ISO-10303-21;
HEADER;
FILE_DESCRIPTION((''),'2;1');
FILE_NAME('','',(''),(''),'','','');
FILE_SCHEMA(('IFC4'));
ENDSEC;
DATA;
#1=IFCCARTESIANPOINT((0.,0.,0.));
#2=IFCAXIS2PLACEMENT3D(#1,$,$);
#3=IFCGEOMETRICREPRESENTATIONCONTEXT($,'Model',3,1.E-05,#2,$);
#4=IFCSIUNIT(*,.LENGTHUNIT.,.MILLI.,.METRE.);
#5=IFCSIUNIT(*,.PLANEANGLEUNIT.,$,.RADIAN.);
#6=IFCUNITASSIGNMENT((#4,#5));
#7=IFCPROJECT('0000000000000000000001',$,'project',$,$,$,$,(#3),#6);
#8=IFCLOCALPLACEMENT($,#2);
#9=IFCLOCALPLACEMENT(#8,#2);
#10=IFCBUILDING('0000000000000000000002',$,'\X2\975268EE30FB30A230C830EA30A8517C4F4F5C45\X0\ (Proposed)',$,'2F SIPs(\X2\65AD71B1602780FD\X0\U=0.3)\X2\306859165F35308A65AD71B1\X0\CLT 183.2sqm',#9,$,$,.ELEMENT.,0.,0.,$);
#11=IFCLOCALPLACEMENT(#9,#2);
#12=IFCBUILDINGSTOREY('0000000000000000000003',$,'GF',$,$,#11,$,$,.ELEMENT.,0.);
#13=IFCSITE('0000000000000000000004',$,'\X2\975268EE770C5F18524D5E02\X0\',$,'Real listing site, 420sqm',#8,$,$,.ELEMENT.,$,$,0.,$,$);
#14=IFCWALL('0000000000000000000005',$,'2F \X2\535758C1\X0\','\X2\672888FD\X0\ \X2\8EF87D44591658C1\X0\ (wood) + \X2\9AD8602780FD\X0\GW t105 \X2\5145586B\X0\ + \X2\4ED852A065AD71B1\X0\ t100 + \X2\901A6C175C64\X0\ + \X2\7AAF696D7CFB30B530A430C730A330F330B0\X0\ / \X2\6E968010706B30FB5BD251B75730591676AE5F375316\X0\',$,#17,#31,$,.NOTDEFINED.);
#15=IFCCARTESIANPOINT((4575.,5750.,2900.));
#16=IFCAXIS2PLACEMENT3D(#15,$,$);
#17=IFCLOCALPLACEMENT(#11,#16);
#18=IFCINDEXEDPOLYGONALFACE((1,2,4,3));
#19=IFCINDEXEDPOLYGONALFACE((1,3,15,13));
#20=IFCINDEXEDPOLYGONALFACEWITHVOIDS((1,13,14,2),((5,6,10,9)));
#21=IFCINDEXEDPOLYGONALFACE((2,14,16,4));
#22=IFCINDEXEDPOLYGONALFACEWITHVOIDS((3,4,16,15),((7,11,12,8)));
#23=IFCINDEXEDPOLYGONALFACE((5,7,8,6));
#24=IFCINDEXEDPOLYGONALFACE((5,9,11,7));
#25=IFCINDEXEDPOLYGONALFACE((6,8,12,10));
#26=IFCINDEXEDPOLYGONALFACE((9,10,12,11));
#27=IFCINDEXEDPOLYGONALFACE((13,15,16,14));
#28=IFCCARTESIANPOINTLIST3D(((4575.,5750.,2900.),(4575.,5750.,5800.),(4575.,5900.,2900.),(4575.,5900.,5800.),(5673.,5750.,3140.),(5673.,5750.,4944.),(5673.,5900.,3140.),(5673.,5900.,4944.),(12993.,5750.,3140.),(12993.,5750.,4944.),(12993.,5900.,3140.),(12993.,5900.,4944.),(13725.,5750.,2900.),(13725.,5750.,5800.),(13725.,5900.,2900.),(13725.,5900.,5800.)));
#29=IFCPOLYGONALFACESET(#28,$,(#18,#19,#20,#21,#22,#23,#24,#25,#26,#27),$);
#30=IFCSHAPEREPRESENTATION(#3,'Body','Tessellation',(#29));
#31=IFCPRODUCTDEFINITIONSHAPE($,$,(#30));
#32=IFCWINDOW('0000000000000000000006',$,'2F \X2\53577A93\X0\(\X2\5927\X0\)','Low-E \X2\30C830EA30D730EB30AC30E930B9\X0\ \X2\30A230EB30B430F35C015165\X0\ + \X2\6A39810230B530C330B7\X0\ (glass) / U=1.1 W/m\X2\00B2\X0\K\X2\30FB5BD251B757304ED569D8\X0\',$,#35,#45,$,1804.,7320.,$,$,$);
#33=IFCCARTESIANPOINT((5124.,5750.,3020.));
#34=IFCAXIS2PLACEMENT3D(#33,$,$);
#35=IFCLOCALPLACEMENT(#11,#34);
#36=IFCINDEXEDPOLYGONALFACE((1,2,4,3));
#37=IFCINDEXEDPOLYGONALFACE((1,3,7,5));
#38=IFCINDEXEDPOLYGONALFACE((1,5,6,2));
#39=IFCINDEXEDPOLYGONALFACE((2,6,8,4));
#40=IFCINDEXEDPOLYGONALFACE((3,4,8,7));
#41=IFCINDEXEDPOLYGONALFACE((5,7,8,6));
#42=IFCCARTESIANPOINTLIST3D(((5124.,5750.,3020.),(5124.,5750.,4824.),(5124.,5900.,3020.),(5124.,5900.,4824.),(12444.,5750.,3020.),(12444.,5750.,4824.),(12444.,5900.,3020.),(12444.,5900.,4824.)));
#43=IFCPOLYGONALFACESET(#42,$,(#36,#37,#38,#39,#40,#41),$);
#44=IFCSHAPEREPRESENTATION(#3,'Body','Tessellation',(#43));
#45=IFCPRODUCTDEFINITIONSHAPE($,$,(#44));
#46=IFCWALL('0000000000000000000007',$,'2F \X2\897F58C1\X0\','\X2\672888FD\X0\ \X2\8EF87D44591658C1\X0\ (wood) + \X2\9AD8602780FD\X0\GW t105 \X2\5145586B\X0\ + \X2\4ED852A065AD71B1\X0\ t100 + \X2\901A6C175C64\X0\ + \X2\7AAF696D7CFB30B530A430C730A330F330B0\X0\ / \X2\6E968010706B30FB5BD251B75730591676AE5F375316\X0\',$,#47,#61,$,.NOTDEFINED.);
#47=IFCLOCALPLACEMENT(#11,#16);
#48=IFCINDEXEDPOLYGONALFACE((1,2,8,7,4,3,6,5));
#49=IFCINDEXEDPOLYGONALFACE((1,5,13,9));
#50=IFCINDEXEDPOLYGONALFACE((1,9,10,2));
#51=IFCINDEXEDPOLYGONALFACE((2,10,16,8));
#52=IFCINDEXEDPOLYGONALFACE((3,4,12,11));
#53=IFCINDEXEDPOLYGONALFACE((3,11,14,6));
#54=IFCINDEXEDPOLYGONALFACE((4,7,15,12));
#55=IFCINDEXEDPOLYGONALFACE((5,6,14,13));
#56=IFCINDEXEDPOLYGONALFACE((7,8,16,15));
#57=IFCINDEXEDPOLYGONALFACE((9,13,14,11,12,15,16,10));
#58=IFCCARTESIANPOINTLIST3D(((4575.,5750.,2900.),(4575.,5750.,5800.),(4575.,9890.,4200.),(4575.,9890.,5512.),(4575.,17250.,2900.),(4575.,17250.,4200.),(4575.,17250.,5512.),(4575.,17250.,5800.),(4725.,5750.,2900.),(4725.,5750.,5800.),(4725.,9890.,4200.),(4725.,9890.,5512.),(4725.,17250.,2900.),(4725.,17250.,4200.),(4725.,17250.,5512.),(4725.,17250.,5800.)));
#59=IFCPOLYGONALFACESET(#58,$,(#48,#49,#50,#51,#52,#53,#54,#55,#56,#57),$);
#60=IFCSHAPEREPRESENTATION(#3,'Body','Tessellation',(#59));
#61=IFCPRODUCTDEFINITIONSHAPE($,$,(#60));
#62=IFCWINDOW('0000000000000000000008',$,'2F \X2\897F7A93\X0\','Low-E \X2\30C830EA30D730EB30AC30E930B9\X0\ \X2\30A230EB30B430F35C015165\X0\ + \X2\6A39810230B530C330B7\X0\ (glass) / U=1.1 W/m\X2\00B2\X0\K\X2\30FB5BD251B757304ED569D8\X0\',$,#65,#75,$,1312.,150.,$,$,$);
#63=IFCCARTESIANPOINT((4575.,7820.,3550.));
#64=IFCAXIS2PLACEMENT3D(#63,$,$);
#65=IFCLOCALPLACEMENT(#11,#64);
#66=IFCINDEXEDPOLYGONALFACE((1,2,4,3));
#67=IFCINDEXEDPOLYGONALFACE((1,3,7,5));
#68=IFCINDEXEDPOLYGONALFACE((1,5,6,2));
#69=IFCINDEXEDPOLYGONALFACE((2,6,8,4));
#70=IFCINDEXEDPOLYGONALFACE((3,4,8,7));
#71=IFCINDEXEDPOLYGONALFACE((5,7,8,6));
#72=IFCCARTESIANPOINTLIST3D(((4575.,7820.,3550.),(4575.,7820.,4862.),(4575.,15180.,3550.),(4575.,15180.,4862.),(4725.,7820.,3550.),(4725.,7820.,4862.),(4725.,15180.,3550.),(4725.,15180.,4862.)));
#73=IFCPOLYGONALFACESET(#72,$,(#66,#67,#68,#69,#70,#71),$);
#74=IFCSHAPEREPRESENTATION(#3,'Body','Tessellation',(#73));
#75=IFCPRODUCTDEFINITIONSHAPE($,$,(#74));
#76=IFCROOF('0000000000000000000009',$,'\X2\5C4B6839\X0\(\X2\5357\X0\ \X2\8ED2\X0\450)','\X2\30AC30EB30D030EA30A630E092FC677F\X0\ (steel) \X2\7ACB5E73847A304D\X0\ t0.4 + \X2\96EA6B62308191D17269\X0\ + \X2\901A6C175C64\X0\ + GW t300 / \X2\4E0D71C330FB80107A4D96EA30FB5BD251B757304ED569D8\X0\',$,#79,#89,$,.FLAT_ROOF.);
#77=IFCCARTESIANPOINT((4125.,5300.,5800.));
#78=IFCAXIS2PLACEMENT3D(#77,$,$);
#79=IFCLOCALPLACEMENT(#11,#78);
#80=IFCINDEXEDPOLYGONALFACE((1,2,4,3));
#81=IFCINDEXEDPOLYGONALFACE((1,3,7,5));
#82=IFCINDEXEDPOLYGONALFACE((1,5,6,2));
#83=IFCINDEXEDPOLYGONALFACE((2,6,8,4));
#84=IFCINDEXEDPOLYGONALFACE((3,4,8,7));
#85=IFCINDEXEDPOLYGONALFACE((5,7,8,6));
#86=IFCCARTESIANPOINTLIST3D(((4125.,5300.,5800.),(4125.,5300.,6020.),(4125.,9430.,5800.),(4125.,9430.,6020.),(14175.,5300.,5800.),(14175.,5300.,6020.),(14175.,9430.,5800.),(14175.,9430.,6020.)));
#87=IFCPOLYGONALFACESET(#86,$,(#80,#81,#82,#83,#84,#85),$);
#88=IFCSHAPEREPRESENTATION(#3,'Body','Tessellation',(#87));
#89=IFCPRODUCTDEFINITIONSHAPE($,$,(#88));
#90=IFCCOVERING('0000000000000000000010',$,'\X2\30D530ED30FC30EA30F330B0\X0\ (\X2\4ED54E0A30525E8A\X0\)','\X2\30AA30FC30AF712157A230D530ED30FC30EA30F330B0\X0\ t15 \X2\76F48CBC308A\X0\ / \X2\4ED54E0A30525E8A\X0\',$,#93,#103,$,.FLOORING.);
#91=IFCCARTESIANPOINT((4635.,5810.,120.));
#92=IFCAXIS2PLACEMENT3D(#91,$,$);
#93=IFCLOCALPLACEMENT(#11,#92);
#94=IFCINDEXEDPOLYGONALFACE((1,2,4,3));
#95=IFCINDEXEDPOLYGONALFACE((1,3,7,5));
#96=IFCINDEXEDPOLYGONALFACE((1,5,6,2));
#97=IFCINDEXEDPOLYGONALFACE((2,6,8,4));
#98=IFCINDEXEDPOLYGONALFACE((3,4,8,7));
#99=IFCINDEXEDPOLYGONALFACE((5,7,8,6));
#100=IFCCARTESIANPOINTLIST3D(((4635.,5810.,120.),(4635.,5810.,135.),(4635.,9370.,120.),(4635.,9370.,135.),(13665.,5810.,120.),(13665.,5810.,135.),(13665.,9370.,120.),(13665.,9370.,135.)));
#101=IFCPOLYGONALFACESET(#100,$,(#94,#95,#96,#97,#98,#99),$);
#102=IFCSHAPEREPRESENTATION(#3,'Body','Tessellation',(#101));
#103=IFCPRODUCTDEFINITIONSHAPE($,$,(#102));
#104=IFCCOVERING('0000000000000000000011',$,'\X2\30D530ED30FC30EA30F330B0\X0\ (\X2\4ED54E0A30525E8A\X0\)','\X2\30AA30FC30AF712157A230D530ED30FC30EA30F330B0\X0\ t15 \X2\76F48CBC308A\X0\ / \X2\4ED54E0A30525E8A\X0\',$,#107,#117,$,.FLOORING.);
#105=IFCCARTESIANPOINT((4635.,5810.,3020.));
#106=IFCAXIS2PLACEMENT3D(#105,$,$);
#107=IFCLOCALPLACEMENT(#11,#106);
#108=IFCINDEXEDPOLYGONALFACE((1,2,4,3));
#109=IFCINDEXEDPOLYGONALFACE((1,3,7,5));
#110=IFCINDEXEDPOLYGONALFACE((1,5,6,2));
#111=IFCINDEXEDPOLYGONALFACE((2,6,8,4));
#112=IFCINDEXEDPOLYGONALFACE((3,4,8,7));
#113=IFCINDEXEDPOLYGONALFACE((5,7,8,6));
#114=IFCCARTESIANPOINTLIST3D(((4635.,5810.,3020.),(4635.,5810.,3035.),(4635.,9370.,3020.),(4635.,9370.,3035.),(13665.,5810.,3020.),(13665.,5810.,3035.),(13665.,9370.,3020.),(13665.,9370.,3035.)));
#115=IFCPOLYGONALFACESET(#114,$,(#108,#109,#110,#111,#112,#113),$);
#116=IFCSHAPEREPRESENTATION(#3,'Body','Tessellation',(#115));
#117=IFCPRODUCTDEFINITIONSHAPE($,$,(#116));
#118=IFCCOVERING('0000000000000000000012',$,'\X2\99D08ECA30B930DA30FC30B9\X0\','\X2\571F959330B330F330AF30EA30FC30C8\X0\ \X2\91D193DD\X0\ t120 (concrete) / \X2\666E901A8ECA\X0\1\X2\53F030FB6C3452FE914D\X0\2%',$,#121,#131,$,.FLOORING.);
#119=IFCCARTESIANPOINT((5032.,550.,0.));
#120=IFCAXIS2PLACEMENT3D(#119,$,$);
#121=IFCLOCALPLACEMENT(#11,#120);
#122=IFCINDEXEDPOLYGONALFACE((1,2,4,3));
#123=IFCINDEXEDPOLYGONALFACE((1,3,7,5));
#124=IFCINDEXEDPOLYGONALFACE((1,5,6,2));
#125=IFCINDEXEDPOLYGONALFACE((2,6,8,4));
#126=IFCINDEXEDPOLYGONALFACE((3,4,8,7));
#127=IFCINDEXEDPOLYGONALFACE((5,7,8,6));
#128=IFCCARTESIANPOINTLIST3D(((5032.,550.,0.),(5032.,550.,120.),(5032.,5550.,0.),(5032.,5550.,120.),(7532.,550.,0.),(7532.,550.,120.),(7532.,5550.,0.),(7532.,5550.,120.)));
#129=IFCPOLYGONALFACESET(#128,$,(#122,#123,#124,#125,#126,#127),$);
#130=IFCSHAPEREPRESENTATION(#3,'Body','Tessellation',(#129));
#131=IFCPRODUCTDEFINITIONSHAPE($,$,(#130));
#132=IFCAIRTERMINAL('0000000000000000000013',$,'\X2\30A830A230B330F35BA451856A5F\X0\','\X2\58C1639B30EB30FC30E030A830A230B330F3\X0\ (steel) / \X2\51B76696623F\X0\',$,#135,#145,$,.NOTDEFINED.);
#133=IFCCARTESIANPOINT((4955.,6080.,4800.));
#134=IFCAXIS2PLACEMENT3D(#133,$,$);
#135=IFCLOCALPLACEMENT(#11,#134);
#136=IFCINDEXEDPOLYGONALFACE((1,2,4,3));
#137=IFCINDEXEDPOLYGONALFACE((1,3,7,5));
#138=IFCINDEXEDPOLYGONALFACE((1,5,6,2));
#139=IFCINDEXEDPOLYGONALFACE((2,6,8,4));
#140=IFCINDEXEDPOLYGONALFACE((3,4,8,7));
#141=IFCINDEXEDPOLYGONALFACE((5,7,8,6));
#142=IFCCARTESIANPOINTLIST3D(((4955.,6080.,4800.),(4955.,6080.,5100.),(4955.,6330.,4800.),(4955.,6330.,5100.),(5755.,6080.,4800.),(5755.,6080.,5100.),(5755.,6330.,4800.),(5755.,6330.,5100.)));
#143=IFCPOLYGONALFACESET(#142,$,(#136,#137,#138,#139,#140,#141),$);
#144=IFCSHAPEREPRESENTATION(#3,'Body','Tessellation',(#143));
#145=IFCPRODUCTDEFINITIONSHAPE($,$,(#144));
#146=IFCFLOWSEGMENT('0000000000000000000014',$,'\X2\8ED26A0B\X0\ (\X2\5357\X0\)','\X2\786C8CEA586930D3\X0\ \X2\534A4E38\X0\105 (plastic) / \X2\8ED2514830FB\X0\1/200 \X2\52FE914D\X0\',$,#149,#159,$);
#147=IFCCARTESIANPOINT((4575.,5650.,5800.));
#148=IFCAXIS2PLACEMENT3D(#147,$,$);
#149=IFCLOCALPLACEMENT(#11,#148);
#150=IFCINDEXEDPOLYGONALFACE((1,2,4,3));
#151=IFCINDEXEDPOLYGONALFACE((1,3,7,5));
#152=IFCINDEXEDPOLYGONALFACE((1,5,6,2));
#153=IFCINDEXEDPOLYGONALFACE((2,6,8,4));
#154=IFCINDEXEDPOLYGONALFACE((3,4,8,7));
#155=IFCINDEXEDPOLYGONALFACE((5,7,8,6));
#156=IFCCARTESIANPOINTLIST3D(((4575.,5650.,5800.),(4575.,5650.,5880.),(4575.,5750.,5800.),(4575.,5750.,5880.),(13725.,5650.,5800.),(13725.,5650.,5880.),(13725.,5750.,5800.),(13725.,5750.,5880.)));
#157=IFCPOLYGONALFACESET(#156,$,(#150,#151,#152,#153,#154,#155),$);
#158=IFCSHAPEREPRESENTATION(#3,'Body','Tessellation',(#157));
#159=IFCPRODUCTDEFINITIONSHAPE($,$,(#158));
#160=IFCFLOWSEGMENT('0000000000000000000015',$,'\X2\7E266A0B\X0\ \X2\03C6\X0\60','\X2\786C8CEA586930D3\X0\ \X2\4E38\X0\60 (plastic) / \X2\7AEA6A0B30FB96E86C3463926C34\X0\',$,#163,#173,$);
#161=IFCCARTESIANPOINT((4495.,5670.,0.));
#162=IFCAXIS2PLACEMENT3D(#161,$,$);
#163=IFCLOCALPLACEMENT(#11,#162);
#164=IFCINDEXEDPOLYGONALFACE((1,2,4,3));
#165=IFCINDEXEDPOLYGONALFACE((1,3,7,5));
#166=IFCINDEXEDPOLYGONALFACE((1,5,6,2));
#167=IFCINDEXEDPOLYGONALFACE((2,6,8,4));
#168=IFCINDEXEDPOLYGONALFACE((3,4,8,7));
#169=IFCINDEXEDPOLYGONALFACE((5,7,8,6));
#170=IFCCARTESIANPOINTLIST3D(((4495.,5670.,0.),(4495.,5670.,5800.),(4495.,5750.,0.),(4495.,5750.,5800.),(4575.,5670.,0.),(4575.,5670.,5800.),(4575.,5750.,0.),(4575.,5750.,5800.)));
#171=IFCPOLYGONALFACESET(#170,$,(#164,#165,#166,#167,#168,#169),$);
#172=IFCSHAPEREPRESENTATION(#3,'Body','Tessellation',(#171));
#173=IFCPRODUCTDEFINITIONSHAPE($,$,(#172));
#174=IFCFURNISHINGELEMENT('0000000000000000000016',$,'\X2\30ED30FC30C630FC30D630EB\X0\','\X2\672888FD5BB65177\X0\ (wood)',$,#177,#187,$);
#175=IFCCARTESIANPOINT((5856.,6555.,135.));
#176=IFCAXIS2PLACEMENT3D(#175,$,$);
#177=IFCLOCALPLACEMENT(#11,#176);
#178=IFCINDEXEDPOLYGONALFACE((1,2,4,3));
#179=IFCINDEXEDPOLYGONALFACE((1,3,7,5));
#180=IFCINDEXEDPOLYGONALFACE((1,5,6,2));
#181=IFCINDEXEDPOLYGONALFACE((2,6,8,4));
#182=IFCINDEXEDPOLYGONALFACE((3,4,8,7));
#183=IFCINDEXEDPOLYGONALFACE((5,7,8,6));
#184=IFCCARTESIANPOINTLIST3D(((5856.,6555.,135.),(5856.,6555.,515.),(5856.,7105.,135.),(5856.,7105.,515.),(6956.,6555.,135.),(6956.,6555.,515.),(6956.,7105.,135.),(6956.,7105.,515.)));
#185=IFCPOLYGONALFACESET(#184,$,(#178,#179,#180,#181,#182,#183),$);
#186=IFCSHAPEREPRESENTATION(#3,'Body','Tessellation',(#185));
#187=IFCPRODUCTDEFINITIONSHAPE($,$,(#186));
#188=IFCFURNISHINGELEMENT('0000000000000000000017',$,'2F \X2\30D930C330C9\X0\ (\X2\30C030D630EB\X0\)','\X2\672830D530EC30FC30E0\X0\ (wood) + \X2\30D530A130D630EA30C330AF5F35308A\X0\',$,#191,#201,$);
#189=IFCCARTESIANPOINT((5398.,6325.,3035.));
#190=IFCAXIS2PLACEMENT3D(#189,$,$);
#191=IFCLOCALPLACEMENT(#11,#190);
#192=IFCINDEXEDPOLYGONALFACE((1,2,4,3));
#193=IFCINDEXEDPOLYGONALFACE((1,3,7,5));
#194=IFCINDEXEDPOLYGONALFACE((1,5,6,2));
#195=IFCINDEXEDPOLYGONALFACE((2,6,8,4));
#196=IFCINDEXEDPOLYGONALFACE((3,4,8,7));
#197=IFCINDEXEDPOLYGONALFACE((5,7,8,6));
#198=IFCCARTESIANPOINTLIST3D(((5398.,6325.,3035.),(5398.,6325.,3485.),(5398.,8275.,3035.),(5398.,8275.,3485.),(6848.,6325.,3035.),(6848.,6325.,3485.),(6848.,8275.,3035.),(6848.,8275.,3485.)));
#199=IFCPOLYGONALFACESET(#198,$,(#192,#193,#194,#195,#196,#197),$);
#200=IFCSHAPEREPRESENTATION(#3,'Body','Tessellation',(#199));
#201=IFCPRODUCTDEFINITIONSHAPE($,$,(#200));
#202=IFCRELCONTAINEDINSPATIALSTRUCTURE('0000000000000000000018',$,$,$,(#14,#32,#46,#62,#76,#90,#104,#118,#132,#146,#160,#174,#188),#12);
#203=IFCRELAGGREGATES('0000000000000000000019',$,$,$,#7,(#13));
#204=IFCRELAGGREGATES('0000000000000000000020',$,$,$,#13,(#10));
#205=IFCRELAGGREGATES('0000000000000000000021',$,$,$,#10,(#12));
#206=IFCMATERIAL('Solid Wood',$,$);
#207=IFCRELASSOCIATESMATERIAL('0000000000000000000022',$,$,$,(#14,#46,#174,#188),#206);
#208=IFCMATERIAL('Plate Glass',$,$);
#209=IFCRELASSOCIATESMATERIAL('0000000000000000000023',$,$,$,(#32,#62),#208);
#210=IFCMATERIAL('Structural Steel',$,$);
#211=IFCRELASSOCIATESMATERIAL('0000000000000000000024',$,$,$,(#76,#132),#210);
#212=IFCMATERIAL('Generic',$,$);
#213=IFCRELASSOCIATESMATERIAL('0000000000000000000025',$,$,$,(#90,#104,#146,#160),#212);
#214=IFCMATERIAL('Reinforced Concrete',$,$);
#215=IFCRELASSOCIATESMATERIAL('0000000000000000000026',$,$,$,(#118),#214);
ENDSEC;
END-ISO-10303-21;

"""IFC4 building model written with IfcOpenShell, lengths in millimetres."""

from ifc_helpers import new_model, si_unit, frame, frame_2d, origin, place, context, project, spatial, rectangle, extrude, material, element, fill, save


model = new_model("IFC4")

# Units and contexts
model_context = context("Model", 3, precision=1e-05, world=origin())
ifc_project = project(units=[si_unit("LENGTHUNIT", "METRE", prefix="MILLI"), si_unit("PLANEANGLEUNIT", "RADIAN")], contexts=[model_context])

# Site, building, storey
site_placement = place(None, origin())
site = spatial("IfcSite", under=ifc_project, at=site_placement, Name="青森県弘前市", ObjectType="Real listing site, 420sqm", CompositionType="ELEMENT", RefElevation=0.0)
building_placement = place(site_placement, origin())
building = spatial("IfcBuilding", under=site, at=building_placement, Name="青森・アトリエ兼住居 (Proposed)", ObjectType="2F SIPs(断熱性能U=0.3)と外張り断熱CLT 183.2sqm", CompositionType="ELEMENT", ElevationOfRefHeight=0.0, ElevationOfTerrain=0.0)
storey_placement = place(building_placement, origin())
storey = spatial("IfcBuildingStorey", under=building, at=storey_placement, Name="GF", CompositionType="ELEMENT", Elevation=0.0)

# Shared definitions
ifc_material_1 = material(Name="Solid Wood")

# Shared definitions
ifc_material_2 = material(Name="Reinforced Concrete")

# Shared definitions
ifc_material_3 = material(Name="Plate Glass")

# Walls, openings, windows
wall_1_placement = place(storey_placement, frame((4575.0, 5750.0, 2900.0)))
wall_1 = element("IfcWall", 1, at=wall_1_placement, inside=storey, material=ifc_material_1, Name="2F 南壁", Description="木製 軸組外壁 (wood) + 高性能GW t105 充填 + 付加断熱 t100 + 通気層 + 窯業系サイディング / 準耐火・寒冷地外皮強化", PredefinedType="NOTDEFINED", context=model_context, shape_type="SweptSolid", body=[
    extrude(rectangle(XDim=9150.0, YDim=150.0, at=frame_2d((4575.0, 75.0))), frame((4575.0, 5750.0, 2900.0)), (0.0, 0.0, 1.0), 2900.0),
])
opening_1_placement = place(storey_placement, frame((5124.0, 5750.0, 3020.0)))
opening_1 = element("IfcOpeningElement", 2, at=opening_1_placement, cuts=wall_1, PredefinedType="NOTDEFINED", context=model_context, shape_type="SweptSolid", body=[
    extrude(rectangle(XDim=7320.0, YDim=150.0, at=frame_2d((3660.0, 75.0))), frame((5124.0, 5750.0, 3020.0)), (0.0, 0.0, 1.0), 1804.0),
])
window_1_placement = place(storey_placement, frame((5124.0, 5750.0, 3020.0)))
window_1 = element("IfcWindow", 3, at=window_1_placement, inside=storey, material=ifc_material_3, Name="2F 南窓(大)", Description="Low-E トリプルガラス アルゴン封入 + 樹脂サッシ (glass) / U=1.1 W/m²K・寒冷地仕様", OverallHeight=1804.0, OverallWidth=7320.0, context=model_context, shape_type="SweptSolid", body=[
    extrude(rectangle(XDim=7320.0, YDim=150.0, at=frame_2d((3660.0, 75.0))), frame((5124.0, 5750.0, 3020.0)), (0.0, 0.0, 1.0), 1804.0),
])
fill(opening_1, window_1)
wall_2_placement = place(storey_placement, frame((4575.0, 5750.0, 2900.0)))
wall_2 = element("IfcWall", 4, at=wall_2_placement, inside=storey, material=ifc_material_1, Name="2F 西壁", Description="木製 軸組外壁 (wood) + 高性能GW t105 充填 + 付加断熱 t100 + 通気層 + 窯業系サイディング / 準耐火・寒冷地外皮強化", PredefinedType="NOTDEFINED", context=model_context, shape_type="SweptSolid", body=[
    extrude(rectangle(XDim=150.0, YDim=11500.0, at=frame_2d((75.0, 5750.0))), frame((4575.0, 5750.0, 2900.0)), (0.0, 0.0, 1.0), 2900.0),
])
opening_2_placement = place(storey_placement, frame((4575.0, 7820.0, 3550.0)))
opening_2 = element("IfcOpeningElement", 5, at=opening_2_placement, cuts=wall_2, PredefinedType="NOTDEFINED", context=model_context, shape_type="SweptSolid", body=[
    extrude(rectangle(XDim=150.0, YDim=7360.0, at=frame_2d((75.0, 3680.0))), frame((4575.0, 7820.0, 3550.0)), (0.0, 0.0, 1.0), 1312.0),
])
window_2_placement = place(storey_placement, frame((4575.0, 7820.0, 3550.0)))
window_2 = element("IfcWindow", 6, at=window_2_placement, inside=storey, material=ifc_material_3, Name="2F 西窓", Description="Low-E トリプルガラス アルゴン封入 + 樹脂サッシ (glass) / U=1.1 W/m²K・寒冷地仕様", OverallHeight=1312.0, OverallWidth=150.0, context=model_context, shape_type="SweptSolid", body=[
    extrude(rectangle(XDim=150.0, YDim=7360.0, at=frame_2d((75.0, 3680.0))), frame((4575.0, 7820.0, 3550.0)), (0.0, 0.0, 1.0), 1312.0),
])
fill(opening_2, window_2)

# Roof
ifc_material_4 = material(Name="Structural Steel")
for number, where, name in (
    (7, (4125.0, 5300.0, 5800.0), "屋根(南 軒450)"),
):
    element("IfcRoof", number, at=place(storey_placement, frame(where)), inside=storey, material=ifc_material_4, Name=name, Description="ガルバリウム鋼板 (steel) 立平葺き t0.4 + 雪止め金物 + 通気層 + GW t300 / 不燃・耐積雪・寒冷地仕様", PredefinedType="FLAT_ROOF", context=model_context, shape_type="SweptSolid", body=[
        extrude(rectangle(XDim=10050.0, YDim=4130.0, at=frame_2d((5025.0, 2065.0))), frame((4125.0, 5300.0, 5800.0)), (0.0, 0.0, 1.0), 220.0),
    ])

# Coverings
ifc_material_5 = material(Name="Generic")
covering_1_placement = place(storey_placement, frame((4635.0, 5810.0, 120.0)))
element("IfcCovering", 8, at=covering_1_placement, inside=storey, material=ifc_material_5, Name="フローリング (仕上げ床)", Description="オーク無垢フローリング t15 直貼り / 仕上げ床", PredefinedType="FLOORING", context=model_context, shape_type="SweptSolid", body=[
    extrude(rectangle(XDim=9030.0, YDim=3560.0, at=frame_2d((4515.0, 1780.0))), frame((4635.0, 5810.0, 120.0)), (0.0, 0.0, 1.0), 15.0),
])
covering_2_placement = place(storey_placement, frame((4635.0, 5810.0, 3020.0)))
element("IfcCovering", 9, at=covering_2_placement, inside=storey, material=ifc_material_5, Name="フローリング (仕上げ床)", Description="オーク無垢フローリング t15 直貼り / 仕上げ床", PredefinedType="FLOORING", context=model_context, shape_type="SweptSolid", body=[
    extrude(rectangle(XDim=9030.0, YDim=3560.0, at=frame_2d((4515.0, 1780.0))), frame((4635.0, 5810.0, 3020.0)), (0.0, 0.0, 1.0), 15.0),
])
covering_3_placement = place(storey_placement, frame((5032.0, 550.0, 0.0)))
element("IfcCovering", 10, at=covering_3_placement, inside=storey, material=ifc_material_2, Name="駐車スペース", Description="土間コンクリート 金鏝 t120 (concrete) / 普通車1台・水勾配2%", PredefinedType="FLOORING", context=model_context, shape_type="SweptSolid", body=[
    extrude(rectangle(XDim=2500.0, YDim=5000.0, at=frame_2d((1250.0, 2500.0))), frame((5032.0, 550.0, 0.0)), (0.0, 0.0, 1.0), 120.0),
])

# Air terminal
air_terminal_placement = place(storey_placement, frame((4955.0, 6080.0, 4800.0)))
element("IfcAirTerminal", 11, at=air_terminal_placement, inside=storey, material=ifc_material_4, Name="エアコン室内機", Description="壁掛ルームエアコン (steel) / 冷暖房", PredefinedType="NOTDEFINED", context=model_context, shape_type="SweptSolid", body=[
    extrude(rectangle(XDim=800.0, YDim=250.0, at=frame_2d((400.0, 125.0))), frame((4955.0, 6080.0, 4800.0)), (0.0, 0.0, 1.0), 300.0),
])

# Flow segments
flow_segment_1_placement = place(storey_placement, frame((4575.0, 5650.0, 5800.0)))
element("IfcFlowSegment", 12, at=flow_segment_1_placement, inside=storey, material=ifc_material_5, Name="軒樋 (南)", Description="硬質塩ビ 半丸105 (plastic) / 軒先・1/200 勾配", context=model_context, shape_type="SweptSolid", body=[
    extrude(rectangle(XDim=9150.0, YDim=100.0, at=frame_2d((4575.0, 50.0))), frame((4575.0, 5650.0, 5800.0)), (0.0, 0.0, 1.0), 80.0),
])
flow_segment_2_placement = place(storey_placement, frame((4495.0, 5670.0, 0.0)))
element("IfcFlowSegment", 13, at=flow_segment_2_placement, inside=storey, material=ifc_material_5, Name="縦樋 φ60", Description="硬質塩ビ 丸60 (plastic) / 竪樋・雨水排水", context=model_context, shape_type="SweptSolid", body=[
    extrude(rectangle(XDim=80.0, YDim=80.0, at=frame_2d((40.0, 40.0))), frame((4495.0, 5670.0, 0.0)), (0.0, 0.0, 1.0), 5800.0),
])

# Furnishing elements
furnishing_1_placement = place(storey_placement, frame((5856.0, 6555.0, 135.0)))
element("IfcFurnishingElement", 14, at=furnishing_1_placement, inside=storey, material=ifc_material_1, Name="ローテーブル", Description="木製家具 (wood)", context=model_context, shape_type="SweptSolid", body=[
    extrude(rectangle(XDim=1100.0, YDim=550.0, at=frame_2d((550.0, 275.0))), frame((5856.0, 6555.0, 135.0)), (0.0, 0.0, 1.0), 380.0),
])
furnishing_2_placement = place(storey_placement, frame((5398.0, 6325.0, 3035.0)))
element("IfcFurnishingElement", 15, at=furnishing_2_placement, inside=storey, material=ifc_material_1, Name="2F ベッド (ダブル)", Description="木フレーム (wood) + ファブリック張り", context=model_context, shape_type="SweptSolid", body=[
    extrude(rectangle(XDim=1450.0, YDim=1950.0, at=frame_2d((725.0, 975.0))), frame((5398.0, 6325.0, 3035.0)), (0.0, 0.0, 1.0), 450.0),
])

save(model, "model.ifc")
